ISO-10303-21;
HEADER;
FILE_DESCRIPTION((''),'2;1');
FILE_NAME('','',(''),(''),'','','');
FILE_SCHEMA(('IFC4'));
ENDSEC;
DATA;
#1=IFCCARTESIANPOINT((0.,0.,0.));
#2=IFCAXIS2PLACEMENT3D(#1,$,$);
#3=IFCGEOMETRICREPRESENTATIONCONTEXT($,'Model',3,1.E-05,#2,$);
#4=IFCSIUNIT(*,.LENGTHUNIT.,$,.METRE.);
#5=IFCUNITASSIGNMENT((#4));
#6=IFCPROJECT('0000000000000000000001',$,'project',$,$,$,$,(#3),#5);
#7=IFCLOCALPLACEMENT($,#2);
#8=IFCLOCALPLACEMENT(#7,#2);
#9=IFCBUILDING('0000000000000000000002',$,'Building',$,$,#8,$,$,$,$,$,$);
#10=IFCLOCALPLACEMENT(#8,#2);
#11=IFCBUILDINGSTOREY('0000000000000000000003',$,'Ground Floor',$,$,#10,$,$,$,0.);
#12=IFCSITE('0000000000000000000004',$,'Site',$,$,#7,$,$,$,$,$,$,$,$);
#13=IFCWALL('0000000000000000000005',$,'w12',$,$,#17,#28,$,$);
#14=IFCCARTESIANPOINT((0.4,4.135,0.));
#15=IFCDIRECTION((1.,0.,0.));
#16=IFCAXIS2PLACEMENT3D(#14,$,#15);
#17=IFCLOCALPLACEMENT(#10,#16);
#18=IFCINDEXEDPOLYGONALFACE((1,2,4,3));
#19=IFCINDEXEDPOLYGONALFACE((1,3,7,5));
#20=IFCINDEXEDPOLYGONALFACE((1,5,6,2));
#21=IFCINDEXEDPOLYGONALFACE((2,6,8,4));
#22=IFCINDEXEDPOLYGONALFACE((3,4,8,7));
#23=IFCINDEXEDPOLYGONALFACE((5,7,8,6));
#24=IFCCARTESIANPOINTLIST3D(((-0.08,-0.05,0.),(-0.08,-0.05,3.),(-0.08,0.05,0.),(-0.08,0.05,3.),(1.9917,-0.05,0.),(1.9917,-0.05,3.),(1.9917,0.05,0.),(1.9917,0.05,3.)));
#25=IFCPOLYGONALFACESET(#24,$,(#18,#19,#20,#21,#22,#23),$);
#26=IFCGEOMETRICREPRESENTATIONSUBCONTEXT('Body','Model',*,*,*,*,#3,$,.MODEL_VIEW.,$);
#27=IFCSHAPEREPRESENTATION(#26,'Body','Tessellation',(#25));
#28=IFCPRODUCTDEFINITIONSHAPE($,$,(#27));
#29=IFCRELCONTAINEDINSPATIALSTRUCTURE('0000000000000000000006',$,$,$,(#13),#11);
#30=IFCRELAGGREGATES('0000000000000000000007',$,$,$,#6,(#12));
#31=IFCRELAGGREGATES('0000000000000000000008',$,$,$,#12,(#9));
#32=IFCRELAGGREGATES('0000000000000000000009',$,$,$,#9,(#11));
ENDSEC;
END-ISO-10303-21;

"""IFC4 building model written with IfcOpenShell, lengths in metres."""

from ifc_helpers import new_model, si_unit, frame, origin, place, context, subcontext, project, spatial, polyline, outline, extrude, element, save


model = new_model("IFC4")

# Units and contexts
model_context = context("Model", 3, precision=1e-05, world=origin())
body_context = subcontext(model_context, "Body", "Model", "MODEL_VIEW")
ifc_project = project(units=[si_unit("LENGTHUNIT", "METRE")], contexts=[model_context])

# Site, building, storey
site_placement = place(None, origin())
site = spatial("IfcSite", under=ifc_project, at=site_placement, Name="Site")
building_placement = place(site_placement, origin())
building = spatial("IfcBuilding", under=site, at=building_placement, Name="Building")
storey_placement = place(building_placement, origin())
storey = spatial("IfcBuildingStorey", under=building, at=storey_placement, Name="Ground Floor", Elevation=0.0)

# Wall
wall_1_placement = place(storey_placement, frame((0.4, 4.135, 0.0), x_axis=(1.0, 0.0, 0.0)))
element("IfcWall", 1, at=wall_1_placement, inside=storey, Name="w12", context=body_context, shape_type="SweptSolid", body=[
    extrude(outline(polyline([(-0.08, -0.05), (1.9917, -0.05), (1.9917, 0.05), (-0.08, 0.05), (-0.08, -0.05)])), origin(), (0.0, 0.0, 1.0), 3.0),
])

save(model, "model.ifc")
